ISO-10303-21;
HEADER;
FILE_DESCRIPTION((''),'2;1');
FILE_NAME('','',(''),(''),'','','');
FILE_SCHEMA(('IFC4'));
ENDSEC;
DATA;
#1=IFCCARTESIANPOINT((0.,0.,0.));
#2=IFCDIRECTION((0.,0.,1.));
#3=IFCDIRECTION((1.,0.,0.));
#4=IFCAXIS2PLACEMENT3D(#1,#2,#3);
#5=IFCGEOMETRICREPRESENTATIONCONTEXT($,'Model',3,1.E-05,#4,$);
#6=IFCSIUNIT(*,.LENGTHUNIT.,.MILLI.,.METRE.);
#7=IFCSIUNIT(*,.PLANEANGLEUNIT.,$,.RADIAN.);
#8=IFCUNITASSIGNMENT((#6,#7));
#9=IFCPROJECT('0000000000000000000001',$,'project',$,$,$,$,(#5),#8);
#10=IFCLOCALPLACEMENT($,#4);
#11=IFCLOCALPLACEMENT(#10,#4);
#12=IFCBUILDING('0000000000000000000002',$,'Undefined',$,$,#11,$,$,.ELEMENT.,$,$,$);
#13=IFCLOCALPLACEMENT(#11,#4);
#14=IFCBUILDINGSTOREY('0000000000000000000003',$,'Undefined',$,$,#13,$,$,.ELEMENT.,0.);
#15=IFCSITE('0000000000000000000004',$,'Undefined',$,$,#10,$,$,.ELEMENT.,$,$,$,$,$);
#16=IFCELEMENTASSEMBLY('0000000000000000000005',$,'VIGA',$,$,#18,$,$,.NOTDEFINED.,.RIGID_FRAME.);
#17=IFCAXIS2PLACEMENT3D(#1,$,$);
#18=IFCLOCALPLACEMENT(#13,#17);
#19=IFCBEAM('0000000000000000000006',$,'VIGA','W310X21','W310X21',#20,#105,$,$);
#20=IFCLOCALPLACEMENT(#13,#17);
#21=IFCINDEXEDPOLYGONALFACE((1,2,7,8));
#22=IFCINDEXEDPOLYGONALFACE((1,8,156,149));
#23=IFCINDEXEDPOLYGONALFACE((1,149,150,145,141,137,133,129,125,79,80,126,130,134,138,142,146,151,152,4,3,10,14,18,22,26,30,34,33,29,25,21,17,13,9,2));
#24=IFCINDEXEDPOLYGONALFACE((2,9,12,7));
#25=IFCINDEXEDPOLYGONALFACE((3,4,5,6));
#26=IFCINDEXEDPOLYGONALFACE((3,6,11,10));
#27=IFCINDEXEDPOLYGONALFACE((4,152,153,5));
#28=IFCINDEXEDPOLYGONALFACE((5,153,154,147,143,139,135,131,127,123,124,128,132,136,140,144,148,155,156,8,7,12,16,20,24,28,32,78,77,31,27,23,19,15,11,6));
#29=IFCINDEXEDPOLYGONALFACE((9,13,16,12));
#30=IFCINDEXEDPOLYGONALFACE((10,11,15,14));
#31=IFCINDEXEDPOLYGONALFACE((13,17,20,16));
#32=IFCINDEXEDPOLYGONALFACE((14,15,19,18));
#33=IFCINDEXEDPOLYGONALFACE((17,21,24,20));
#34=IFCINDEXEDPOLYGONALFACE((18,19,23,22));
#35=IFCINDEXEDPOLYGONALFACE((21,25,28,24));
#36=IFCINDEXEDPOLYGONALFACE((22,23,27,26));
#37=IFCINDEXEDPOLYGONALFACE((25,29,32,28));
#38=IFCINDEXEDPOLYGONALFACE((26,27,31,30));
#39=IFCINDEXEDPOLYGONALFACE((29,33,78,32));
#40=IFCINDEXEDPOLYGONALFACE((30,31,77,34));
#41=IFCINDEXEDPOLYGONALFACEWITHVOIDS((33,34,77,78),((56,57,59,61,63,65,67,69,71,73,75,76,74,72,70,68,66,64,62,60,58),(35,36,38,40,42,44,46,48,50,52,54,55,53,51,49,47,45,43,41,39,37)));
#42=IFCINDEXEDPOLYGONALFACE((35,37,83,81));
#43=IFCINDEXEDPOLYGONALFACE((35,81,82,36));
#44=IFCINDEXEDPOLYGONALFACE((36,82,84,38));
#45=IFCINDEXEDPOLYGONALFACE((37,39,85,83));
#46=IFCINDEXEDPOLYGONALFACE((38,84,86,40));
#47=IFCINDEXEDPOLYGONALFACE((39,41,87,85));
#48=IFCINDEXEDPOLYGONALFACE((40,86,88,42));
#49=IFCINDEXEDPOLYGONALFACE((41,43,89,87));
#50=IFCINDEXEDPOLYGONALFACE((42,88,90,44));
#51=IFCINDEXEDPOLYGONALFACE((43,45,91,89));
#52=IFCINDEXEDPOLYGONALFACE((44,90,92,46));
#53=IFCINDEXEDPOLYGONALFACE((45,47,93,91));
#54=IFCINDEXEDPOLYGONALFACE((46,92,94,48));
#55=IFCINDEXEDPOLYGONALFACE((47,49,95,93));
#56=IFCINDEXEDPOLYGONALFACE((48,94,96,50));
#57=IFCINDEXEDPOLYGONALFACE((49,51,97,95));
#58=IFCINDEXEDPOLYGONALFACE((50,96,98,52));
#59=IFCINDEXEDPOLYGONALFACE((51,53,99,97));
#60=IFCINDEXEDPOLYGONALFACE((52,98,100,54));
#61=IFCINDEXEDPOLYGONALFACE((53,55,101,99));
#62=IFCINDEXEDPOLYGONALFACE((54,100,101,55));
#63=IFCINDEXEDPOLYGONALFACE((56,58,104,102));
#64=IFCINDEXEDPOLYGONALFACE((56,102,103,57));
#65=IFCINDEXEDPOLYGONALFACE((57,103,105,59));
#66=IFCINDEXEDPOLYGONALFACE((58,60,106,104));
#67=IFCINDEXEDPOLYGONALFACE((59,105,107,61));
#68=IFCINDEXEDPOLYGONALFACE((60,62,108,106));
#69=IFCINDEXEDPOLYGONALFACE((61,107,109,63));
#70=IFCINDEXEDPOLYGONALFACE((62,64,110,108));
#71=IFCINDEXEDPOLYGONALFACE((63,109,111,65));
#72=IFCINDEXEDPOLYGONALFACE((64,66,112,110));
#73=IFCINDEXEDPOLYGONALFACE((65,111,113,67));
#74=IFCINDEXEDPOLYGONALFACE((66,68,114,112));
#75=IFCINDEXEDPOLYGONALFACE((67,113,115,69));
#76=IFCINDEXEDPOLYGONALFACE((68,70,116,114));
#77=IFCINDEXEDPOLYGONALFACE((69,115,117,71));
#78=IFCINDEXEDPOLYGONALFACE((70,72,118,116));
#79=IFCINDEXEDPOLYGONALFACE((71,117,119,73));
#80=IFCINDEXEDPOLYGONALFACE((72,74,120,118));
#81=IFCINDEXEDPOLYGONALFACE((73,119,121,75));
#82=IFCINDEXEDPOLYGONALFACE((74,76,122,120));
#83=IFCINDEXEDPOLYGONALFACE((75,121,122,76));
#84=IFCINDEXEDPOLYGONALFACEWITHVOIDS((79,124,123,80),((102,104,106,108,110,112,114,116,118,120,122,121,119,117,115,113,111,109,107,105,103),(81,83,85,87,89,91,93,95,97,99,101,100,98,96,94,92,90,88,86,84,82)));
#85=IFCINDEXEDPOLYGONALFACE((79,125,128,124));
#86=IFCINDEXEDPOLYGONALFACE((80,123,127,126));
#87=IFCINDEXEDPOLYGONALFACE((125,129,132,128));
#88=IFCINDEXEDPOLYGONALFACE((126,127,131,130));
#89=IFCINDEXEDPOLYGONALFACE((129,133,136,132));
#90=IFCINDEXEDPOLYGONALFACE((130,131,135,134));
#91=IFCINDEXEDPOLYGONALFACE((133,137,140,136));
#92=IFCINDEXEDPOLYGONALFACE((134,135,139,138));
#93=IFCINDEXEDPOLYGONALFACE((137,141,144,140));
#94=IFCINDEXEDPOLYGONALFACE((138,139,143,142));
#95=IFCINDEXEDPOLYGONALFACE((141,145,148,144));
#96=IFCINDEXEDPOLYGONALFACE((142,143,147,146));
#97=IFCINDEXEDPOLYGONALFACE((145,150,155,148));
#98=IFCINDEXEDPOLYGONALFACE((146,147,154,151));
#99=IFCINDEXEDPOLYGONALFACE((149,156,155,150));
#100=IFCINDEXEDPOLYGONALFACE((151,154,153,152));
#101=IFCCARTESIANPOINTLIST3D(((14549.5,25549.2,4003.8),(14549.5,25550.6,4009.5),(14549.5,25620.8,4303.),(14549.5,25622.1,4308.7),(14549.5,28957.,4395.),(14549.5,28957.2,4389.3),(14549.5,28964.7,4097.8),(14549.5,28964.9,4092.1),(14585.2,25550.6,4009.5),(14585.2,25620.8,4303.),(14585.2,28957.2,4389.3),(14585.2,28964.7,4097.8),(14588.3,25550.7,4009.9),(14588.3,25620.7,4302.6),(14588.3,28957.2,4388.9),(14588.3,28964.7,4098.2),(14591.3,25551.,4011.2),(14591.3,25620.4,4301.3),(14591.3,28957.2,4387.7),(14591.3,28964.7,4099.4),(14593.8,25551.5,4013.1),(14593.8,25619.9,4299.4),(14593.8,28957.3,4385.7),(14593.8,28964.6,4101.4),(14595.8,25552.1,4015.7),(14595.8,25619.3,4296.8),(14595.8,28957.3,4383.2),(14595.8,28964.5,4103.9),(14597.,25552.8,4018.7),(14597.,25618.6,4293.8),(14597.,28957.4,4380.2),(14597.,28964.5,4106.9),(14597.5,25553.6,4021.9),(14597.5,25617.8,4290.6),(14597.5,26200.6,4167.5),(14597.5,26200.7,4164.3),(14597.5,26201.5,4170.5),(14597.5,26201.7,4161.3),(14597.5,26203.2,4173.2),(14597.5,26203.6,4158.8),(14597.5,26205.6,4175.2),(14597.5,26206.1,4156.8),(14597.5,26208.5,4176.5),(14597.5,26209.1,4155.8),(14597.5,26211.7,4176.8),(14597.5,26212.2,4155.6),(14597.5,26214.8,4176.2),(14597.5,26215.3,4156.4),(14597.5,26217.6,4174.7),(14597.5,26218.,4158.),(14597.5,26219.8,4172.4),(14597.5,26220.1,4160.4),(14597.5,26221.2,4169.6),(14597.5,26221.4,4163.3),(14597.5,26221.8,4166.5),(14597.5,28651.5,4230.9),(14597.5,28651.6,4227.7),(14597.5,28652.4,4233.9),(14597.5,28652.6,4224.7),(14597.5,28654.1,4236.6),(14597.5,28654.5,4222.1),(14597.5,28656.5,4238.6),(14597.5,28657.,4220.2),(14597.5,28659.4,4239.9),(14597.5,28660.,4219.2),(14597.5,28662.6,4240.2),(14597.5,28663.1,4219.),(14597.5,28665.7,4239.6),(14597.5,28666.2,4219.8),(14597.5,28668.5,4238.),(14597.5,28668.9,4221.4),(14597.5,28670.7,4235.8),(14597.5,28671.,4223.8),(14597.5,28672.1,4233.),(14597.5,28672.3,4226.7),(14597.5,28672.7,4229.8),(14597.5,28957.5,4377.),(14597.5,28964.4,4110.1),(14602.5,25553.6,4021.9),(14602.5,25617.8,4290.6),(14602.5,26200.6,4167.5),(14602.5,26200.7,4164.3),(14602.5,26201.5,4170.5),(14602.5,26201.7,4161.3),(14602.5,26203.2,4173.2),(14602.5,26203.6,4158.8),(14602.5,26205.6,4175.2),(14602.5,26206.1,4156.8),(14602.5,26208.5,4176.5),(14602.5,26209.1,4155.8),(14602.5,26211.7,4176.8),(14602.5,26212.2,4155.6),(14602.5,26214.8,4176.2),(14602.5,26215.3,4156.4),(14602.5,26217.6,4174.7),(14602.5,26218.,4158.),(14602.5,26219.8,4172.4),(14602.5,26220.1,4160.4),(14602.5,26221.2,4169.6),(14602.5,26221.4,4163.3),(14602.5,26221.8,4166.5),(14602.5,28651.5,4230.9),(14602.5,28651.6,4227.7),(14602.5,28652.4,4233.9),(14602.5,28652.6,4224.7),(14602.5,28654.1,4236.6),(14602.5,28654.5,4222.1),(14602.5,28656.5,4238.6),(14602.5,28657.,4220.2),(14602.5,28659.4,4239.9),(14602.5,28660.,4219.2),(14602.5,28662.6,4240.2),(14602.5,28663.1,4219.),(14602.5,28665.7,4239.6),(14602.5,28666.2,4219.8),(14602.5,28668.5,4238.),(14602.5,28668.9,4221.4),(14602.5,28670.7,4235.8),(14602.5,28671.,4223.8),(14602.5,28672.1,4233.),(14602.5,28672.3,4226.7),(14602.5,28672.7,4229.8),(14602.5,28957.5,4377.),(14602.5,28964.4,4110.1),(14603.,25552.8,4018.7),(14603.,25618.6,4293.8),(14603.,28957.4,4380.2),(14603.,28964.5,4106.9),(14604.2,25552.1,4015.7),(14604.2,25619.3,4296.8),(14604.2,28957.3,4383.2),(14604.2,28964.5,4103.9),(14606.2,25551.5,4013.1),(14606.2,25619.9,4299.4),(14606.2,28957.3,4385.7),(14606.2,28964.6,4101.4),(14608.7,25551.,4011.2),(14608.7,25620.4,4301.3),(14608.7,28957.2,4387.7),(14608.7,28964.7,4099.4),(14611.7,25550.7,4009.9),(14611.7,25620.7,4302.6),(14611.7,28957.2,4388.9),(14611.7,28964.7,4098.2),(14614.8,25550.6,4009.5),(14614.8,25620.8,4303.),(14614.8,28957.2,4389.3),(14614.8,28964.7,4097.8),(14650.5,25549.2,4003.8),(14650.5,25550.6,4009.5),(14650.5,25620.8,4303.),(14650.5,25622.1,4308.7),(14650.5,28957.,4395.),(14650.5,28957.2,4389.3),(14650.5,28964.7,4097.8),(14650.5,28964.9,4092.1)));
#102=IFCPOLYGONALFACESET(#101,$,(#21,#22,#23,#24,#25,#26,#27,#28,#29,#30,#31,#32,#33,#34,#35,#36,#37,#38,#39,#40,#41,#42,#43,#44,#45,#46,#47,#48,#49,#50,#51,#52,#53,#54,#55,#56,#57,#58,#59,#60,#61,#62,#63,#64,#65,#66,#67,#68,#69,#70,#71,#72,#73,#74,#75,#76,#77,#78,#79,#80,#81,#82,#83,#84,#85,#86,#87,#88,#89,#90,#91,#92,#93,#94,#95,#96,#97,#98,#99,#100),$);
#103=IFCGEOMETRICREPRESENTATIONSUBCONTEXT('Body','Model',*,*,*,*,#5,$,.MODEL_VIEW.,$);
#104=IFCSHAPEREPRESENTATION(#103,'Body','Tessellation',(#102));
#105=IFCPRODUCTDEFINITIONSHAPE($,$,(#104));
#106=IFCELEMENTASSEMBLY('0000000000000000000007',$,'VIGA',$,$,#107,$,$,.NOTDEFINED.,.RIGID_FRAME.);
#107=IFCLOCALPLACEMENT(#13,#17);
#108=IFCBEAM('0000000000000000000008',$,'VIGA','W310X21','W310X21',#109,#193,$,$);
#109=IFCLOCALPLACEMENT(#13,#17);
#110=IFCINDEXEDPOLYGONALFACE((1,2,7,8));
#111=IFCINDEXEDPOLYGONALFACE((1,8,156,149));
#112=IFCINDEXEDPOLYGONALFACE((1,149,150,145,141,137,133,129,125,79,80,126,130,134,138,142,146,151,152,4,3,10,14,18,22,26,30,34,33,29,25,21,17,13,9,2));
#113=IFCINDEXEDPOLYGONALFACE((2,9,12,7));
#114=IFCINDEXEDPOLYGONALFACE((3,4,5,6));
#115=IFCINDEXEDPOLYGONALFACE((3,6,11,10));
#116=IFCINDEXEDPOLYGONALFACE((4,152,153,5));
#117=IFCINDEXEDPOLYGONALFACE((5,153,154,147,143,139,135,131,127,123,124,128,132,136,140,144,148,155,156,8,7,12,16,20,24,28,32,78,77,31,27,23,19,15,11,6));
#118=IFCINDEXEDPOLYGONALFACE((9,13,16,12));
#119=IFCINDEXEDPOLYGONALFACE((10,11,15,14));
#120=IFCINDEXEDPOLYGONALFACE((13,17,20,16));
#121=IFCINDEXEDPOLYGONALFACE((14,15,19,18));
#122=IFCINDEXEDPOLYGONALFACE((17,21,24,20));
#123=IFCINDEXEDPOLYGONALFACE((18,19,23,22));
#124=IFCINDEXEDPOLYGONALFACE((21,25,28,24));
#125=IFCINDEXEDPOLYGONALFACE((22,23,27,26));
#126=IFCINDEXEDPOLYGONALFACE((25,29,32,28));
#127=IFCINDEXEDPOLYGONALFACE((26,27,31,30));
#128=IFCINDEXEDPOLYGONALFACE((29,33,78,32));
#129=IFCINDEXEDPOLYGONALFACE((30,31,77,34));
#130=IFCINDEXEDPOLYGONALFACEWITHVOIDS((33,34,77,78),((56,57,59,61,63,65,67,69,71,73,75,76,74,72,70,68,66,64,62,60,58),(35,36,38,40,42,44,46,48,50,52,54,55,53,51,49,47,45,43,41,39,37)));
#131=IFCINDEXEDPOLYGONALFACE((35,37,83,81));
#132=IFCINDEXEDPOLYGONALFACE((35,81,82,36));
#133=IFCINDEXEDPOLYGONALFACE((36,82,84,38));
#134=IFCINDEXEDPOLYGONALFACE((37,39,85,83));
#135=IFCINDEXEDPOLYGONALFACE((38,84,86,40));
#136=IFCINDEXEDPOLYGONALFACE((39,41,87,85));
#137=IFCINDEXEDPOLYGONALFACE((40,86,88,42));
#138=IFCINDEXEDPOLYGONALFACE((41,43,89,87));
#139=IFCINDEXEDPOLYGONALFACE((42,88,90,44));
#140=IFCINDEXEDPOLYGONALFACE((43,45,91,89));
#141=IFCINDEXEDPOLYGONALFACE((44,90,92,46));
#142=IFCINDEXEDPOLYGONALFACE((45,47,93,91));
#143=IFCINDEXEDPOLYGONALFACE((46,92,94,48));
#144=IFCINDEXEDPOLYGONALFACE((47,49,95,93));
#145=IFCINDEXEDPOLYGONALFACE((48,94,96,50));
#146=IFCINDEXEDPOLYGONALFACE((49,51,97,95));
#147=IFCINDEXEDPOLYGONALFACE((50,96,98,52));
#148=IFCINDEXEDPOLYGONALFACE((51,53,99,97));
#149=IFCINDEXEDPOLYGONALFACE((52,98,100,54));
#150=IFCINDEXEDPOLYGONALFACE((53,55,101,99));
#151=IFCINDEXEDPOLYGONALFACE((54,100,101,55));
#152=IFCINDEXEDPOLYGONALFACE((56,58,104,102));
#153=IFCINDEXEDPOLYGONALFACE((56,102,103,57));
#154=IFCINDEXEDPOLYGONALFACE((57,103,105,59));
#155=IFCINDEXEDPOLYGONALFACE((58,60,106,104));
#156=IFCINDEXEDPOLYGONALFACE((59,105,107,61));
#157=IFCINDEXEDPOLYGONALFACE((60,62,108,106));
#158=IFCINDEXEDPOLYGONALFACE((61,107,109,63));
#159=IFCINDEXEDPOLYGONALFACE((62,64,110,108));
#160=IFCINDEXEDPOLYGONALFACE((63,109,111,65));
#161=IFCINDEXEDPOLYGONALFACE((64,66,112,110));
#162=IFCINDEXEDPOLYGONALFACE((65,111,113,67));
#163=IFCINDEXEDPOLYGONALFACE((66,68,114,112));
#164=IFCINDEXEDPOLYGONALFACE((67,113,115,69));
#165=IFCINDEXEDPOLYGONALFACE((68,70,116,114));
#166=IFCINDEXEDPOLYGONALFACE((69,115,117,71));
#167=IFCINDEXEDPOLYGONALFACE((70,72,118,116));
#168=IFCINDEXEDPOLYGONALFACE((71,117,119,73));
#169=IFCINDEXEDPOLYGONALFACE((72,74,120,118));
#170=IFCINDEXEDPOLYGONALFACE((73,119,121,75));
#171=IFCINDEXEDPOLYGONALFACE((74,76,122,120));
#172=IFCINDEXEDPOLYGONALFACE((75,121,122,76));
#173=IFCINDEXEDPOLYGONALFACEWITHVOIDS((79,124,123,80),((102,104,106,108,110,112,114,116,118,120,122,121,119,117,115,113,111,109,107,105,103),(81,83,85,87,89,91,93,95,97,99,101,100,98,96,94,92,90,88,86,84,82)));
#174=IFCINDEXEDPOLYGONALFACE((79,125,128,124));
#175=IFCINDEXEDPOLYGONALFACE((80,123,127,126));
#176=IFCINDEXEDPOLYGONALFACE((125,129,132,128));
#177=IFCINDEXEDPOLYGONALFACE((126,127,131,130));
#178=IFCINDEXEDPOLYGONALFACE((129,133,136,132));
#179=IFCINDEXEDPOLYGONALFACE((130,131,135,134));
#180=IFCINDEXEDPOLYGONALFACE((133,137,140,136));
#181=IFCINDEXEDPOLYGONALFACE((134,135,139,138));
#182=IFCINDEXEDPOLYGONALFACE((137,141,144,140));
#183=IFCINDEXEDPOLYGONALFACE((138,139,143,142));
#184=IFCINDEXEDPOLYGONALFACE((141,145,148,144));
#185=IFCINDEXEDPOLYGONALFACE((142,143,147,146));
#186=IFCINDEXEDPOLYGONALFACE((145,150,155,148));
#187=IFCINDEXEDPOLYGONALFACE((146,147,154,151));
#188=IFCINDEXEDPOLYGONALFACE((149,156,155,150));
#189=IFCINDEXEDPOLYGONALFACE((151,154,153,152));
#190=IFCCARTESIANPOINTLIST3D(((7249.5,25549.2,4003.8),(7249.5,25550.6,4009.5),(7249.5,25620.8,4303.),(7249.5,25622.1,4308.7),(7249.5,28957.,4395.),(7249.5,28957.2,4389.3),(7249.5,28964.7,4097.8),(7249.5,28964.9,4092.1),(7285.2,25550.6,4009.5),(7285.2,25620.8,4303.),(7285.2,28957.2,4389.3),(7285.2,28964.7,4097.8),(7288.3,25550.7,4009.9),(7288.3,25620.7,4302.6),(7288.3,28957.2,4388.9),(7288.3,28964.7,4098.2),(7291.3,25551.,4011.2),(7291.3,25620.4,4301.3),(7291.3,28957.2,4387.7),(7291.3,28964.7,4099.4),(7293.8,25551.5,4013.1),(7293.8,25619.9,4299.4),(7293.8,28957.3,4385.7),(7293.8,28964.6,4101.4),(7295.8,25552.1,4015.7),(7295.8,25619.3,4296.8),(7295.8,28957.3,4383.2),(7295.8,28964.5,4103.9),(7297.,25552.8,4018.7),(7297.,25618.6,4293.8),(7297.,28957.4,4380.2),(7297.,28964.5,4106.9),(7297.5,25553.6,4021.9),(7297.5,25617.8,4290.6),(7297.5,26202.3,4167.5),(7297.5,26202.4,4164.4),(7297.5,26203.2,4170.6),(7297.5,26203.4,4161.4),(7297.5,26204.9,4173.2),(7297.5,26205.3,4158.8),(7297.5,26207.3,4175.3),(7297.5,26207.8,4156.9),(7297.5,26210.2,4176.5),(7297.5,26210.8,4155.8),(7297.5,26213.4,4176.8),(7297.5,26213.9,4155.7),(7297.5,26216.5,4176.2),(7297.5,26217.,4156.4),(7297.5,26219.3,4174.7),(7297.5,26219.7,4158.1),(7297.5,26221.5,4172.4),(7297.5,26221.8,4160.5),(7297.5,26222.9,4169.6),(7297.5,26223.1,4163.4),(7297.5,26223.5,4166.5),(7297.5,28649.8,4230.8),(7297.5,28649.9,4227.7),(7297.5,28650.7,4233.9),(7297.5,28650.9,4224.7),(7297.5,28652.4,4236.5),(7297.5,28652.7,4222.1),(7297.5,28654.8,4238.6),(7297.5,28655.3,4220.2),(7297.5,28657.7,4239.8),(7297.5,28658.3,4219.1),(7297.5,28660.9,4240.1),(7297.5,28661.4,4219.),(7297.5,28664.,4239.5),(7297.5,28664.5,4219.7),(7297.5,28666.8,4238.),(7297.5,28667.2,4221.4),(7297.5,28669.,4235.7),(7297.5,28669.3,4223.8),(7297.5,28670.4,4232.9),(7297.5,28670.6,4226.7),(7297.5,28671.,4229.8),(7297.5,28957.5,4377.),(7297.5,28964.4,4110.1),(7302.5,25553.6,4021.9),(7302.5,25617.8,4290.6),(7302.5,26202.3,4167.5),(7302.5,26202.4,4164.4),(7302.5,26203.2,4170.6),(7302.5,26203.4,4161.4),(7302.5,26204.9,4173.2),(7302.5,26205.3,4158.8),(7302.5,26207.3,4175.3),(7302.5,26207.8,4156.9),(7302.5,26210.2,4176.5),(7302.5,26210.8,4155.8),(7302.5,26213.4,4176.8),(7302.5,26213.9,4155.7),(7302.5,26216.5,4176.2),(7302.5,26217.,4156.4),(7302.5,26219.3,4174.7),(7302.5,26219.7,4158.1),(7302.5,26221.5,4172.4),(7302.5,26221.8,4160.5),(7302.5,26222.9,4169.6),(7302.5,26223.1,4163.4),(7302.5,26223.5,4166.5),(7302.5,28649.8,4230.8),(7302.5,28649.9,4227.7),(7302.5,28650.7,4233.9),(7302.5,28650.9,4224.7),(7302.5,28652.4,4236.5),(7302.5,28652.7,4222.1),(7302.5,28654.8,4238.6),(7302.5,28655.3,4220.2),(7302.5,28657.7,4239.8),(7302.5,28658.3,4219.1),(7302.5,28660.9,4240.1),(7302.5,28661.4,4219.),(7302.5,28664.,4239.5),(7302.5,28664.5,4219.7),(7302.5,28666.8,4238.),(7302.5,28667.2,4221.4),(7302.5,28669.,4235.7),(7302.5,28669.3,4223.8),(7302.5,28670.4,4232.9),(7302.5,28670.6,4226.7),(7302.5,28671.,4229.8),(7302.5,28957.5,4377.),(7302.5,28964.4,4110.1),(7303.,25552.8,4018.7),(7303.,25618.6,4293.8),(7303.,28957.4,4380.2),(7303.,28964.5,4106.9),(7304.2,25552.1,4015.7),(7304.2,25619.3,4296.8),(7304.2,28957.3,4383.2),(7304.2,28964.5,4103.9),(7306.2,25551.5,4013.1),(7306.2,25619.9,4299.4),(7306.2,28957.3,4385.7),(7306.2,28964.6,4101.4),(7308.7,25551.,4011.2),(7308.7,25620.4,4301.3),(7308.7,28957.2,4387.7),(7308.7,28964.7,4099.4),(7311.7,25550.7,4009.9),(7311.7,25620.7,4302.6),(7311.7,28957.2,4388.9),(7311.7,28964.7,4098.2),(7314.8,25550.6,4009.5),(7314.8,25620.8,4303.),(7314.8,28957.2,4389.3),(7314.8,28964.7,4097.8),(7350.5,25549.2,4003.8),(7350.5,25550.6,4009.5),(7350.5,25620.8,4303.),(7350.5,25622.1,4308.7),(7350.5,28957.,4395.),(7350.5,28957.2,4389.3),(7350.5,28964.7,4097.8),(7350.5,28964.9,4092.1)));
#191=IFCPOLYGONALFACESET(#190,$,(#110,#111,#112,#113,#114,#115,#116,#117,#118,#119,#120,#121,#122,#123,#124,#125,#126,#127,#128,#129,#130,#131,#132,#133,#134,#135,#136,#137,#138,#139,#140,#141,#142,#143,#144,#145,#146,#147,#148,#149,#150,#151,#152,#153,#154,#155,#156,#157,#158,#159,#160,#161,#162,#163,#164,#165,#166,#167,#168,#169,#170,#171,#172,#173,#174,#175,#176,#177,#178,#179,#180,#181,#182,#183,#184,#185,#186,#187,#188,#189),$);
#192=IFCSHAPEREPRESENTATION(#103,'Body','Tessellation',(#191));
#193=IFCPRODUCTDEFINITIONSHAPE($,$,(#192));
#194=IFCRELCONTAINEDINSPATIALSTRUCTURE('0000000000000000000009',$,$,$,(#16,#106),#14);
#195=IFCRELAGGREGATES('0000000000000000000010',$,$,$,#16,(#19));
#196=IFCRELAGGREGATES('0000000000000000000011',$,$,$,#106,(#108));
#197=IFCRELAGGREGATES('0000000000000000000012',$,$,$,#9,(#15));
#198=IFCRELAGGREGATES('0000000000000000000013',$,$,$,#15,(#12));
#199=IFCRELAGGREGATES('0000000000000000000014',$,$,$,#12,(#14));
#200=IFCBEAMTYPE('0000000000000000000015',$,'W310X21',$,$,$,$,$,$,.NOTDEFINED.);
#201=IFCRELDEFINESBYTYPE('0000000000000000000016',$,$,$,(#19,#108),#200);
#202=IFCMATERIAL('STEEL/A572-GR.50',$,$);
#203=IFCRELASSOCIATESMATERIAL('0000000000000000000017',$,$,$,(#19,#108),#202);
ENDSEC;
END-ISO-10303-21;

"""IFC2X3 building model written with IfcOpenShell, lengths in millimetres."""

from ifc_helpers import new_model, si_unit, frame, origin_with_axes, origin_2d_with_axis, place, context, subcontext, project, spatial, circle, i_section, extrude, boolean, halfspace, material, type_object, element, aggregate, save


model = new_model("IFC2X3")

# Units and contexts
model_context = context("Model", 3, precision=1e-05, world=origin_with_axes())
body_context = subcontext(model_context, "Body", "Model", "MODEL_VIEW")
ifc_project = project(units=[si_unit("LENGTHUNIT", "METRE", prefix="MILLI"), si_unit("PLANEANGLEUNIT", "RADIAN")], contexts=[model_context])

# Site, building, storey
site_placement = place(None, origin_with_axes())
site = spatial("IfcSite", under=ifc_project, at=site_placement, Name="Undefined", CompositionType="ELEMENT")
building_placement = place(site_placement, origin_with_axes())
building = spatial("IfcBuilding", under=site, at=building_placement, Name="Undefined", CompositionType="ELEMENT")
storey_placement = place(building_placement, origin_with_axes())
storey = spatial("IfcBuildingStorey", under=building, at=storey_placement, Name="Undefined", CompositionType="ELEMENT", Elevation=0.0)

# Element assemblies, beams
ifc_material_1 = material(Name="STEEL/A572-GR.50")
assembly_1_placement = place(storey_placement, origin_with_axes())
assembly_1 = element("IfcElementAssembly", 1, at=assembly_1_placement, inside=storey, Name="VIGA", AssemblyPlace="NOTDEFINED", PredefinedType="RIGID_FRAME")
beam_type_1 = type_object("IfcBeamType", Name="W310X21", PredefinedType="NOTDEFINED")
beam_1_placement = place(assembly_1_placement, frame((14600.0, 25403.9, 4151.6), z_axis=(0.0, -0.025855, 0.999666), x_axis=(0.0, 0.999666, 0.025855)))
beam_1 = element("IfcBeam", 2, at=beam_1_placement, type_object=beam_type_1, material=ifc_material_1, Name="VIGA", Description="W310X21", ObjectType="W310X21", context=body_context, shape_type="CSG", body=[
    boolean("DIFFERENCE", boolean("DIFFERENCE", boolean("DIFFERENCE", extrude(i_section(OverallWidth=101.0, OverallDepth=303.0, WebThickness=5.1, FlangeThickness=5.7, FilletRadius=12.3, at=origin_2d_with_axis()), frame((3558.2, 0.0, 0.0), z_axis=(-1.0, 0.0, 0.0), x_axis=(0.0, -1.0, 0.0)), (0.0, 0.0, 1.0), 3558.2), extrude(circle(Radius=10.6, at=origin_2d_with_axis()), frame((3259.1, -100.0, -6.3), z_axis=(0.0, 1.0, 0.0), x_axis=(1.0, 0.0, 0.0)), (0.0, 0.0, 1.0), 200.0)), extrude(circle(Radius=10.6, at=origin_2d_with_axis()), frame((807.4, -100.0, -6.2), z_axis=(0.0, 1.0, 0.0), x_axis=(1.0, 0.0, 0.0)), (0.0, 0.0, 1.0), 200.0)), halfspace(frame((141.4, -50.5, -151.7), z_axis=(-0.966259, 0.0, 0.257573), x_axis=(0.0, 1.0, 0.0)), False)),
])
aggregate(assembly_1, [beam_1])
assembly_2_placement = place(storey_placement, origin_with_axes())
assembly_2 = element("IfcElementAssembly", 3, at=assembly_2_placement, inside=storey, Name="VIGA", AssemblyPlace="NOTDEFINED", PredefinedType="RIGID_FRAME")
beam_2_placement = place(assembly_2_placement, frame((7300.0, 25403.9, 4151.6), z_axis=(0.0, -0.025855, 0.999666), x_axis=(0.0, 0.999666, 0.025855)))
beam_2 = element("IfcBeam", 4, at=beam_2_placement, type_object=beam_type_1, material=ifc_material_1, Name="VIGA", Description="W310X21", ObjectType="W310X21", context=body_context, shape_type="CSG", body=[
    boolean("DIFFERENCE", boolean("DIFFERENCE", boolean("DIFFERENCE", extrude(i_section(OverallWidth=101.0, OverallDepth=303.0, WebThickness=5.1, FlangeThickness=5.7, FilletRadius=12.3, at=origin_2d_with_axis()), frame((3558.2, 0.0, 0.0), z_axis=(-1.0, 0.0, 0.0), x_axis=(0.0, -1.0, 0.0)), (0.0, 0.0, 1.0), 3558.2), extrude(circle(Radius=10.6, at=origin_2d_with_axis()), frame((809.1, 100.0, -6.3), z_axis=(0.0, -1.0, 0.0), x_axis=(1.0, 0.0, 0.0)), (0.0, 0.0, 1.0), 200.0)), extrude(circle(Radius=10.6, at=origin_2d_with_axis()), frame((3257.4, 100.0, -6.3), z_axis=(0.0, -1.0, 0.0), x_axis=(1.0, 0.0, 0.0)), (0.0, 0.0, 1.0), 200.0)), halfspace(frame((141.4, -50.5, -151.7), z_axis=(-0.966259, 0.0, 0.257573), x_axis=(0.0, 1.0, 0.0)), False)),
])
aggregate(assembly_2, [beam_2])

save(model, "model.ifc")
